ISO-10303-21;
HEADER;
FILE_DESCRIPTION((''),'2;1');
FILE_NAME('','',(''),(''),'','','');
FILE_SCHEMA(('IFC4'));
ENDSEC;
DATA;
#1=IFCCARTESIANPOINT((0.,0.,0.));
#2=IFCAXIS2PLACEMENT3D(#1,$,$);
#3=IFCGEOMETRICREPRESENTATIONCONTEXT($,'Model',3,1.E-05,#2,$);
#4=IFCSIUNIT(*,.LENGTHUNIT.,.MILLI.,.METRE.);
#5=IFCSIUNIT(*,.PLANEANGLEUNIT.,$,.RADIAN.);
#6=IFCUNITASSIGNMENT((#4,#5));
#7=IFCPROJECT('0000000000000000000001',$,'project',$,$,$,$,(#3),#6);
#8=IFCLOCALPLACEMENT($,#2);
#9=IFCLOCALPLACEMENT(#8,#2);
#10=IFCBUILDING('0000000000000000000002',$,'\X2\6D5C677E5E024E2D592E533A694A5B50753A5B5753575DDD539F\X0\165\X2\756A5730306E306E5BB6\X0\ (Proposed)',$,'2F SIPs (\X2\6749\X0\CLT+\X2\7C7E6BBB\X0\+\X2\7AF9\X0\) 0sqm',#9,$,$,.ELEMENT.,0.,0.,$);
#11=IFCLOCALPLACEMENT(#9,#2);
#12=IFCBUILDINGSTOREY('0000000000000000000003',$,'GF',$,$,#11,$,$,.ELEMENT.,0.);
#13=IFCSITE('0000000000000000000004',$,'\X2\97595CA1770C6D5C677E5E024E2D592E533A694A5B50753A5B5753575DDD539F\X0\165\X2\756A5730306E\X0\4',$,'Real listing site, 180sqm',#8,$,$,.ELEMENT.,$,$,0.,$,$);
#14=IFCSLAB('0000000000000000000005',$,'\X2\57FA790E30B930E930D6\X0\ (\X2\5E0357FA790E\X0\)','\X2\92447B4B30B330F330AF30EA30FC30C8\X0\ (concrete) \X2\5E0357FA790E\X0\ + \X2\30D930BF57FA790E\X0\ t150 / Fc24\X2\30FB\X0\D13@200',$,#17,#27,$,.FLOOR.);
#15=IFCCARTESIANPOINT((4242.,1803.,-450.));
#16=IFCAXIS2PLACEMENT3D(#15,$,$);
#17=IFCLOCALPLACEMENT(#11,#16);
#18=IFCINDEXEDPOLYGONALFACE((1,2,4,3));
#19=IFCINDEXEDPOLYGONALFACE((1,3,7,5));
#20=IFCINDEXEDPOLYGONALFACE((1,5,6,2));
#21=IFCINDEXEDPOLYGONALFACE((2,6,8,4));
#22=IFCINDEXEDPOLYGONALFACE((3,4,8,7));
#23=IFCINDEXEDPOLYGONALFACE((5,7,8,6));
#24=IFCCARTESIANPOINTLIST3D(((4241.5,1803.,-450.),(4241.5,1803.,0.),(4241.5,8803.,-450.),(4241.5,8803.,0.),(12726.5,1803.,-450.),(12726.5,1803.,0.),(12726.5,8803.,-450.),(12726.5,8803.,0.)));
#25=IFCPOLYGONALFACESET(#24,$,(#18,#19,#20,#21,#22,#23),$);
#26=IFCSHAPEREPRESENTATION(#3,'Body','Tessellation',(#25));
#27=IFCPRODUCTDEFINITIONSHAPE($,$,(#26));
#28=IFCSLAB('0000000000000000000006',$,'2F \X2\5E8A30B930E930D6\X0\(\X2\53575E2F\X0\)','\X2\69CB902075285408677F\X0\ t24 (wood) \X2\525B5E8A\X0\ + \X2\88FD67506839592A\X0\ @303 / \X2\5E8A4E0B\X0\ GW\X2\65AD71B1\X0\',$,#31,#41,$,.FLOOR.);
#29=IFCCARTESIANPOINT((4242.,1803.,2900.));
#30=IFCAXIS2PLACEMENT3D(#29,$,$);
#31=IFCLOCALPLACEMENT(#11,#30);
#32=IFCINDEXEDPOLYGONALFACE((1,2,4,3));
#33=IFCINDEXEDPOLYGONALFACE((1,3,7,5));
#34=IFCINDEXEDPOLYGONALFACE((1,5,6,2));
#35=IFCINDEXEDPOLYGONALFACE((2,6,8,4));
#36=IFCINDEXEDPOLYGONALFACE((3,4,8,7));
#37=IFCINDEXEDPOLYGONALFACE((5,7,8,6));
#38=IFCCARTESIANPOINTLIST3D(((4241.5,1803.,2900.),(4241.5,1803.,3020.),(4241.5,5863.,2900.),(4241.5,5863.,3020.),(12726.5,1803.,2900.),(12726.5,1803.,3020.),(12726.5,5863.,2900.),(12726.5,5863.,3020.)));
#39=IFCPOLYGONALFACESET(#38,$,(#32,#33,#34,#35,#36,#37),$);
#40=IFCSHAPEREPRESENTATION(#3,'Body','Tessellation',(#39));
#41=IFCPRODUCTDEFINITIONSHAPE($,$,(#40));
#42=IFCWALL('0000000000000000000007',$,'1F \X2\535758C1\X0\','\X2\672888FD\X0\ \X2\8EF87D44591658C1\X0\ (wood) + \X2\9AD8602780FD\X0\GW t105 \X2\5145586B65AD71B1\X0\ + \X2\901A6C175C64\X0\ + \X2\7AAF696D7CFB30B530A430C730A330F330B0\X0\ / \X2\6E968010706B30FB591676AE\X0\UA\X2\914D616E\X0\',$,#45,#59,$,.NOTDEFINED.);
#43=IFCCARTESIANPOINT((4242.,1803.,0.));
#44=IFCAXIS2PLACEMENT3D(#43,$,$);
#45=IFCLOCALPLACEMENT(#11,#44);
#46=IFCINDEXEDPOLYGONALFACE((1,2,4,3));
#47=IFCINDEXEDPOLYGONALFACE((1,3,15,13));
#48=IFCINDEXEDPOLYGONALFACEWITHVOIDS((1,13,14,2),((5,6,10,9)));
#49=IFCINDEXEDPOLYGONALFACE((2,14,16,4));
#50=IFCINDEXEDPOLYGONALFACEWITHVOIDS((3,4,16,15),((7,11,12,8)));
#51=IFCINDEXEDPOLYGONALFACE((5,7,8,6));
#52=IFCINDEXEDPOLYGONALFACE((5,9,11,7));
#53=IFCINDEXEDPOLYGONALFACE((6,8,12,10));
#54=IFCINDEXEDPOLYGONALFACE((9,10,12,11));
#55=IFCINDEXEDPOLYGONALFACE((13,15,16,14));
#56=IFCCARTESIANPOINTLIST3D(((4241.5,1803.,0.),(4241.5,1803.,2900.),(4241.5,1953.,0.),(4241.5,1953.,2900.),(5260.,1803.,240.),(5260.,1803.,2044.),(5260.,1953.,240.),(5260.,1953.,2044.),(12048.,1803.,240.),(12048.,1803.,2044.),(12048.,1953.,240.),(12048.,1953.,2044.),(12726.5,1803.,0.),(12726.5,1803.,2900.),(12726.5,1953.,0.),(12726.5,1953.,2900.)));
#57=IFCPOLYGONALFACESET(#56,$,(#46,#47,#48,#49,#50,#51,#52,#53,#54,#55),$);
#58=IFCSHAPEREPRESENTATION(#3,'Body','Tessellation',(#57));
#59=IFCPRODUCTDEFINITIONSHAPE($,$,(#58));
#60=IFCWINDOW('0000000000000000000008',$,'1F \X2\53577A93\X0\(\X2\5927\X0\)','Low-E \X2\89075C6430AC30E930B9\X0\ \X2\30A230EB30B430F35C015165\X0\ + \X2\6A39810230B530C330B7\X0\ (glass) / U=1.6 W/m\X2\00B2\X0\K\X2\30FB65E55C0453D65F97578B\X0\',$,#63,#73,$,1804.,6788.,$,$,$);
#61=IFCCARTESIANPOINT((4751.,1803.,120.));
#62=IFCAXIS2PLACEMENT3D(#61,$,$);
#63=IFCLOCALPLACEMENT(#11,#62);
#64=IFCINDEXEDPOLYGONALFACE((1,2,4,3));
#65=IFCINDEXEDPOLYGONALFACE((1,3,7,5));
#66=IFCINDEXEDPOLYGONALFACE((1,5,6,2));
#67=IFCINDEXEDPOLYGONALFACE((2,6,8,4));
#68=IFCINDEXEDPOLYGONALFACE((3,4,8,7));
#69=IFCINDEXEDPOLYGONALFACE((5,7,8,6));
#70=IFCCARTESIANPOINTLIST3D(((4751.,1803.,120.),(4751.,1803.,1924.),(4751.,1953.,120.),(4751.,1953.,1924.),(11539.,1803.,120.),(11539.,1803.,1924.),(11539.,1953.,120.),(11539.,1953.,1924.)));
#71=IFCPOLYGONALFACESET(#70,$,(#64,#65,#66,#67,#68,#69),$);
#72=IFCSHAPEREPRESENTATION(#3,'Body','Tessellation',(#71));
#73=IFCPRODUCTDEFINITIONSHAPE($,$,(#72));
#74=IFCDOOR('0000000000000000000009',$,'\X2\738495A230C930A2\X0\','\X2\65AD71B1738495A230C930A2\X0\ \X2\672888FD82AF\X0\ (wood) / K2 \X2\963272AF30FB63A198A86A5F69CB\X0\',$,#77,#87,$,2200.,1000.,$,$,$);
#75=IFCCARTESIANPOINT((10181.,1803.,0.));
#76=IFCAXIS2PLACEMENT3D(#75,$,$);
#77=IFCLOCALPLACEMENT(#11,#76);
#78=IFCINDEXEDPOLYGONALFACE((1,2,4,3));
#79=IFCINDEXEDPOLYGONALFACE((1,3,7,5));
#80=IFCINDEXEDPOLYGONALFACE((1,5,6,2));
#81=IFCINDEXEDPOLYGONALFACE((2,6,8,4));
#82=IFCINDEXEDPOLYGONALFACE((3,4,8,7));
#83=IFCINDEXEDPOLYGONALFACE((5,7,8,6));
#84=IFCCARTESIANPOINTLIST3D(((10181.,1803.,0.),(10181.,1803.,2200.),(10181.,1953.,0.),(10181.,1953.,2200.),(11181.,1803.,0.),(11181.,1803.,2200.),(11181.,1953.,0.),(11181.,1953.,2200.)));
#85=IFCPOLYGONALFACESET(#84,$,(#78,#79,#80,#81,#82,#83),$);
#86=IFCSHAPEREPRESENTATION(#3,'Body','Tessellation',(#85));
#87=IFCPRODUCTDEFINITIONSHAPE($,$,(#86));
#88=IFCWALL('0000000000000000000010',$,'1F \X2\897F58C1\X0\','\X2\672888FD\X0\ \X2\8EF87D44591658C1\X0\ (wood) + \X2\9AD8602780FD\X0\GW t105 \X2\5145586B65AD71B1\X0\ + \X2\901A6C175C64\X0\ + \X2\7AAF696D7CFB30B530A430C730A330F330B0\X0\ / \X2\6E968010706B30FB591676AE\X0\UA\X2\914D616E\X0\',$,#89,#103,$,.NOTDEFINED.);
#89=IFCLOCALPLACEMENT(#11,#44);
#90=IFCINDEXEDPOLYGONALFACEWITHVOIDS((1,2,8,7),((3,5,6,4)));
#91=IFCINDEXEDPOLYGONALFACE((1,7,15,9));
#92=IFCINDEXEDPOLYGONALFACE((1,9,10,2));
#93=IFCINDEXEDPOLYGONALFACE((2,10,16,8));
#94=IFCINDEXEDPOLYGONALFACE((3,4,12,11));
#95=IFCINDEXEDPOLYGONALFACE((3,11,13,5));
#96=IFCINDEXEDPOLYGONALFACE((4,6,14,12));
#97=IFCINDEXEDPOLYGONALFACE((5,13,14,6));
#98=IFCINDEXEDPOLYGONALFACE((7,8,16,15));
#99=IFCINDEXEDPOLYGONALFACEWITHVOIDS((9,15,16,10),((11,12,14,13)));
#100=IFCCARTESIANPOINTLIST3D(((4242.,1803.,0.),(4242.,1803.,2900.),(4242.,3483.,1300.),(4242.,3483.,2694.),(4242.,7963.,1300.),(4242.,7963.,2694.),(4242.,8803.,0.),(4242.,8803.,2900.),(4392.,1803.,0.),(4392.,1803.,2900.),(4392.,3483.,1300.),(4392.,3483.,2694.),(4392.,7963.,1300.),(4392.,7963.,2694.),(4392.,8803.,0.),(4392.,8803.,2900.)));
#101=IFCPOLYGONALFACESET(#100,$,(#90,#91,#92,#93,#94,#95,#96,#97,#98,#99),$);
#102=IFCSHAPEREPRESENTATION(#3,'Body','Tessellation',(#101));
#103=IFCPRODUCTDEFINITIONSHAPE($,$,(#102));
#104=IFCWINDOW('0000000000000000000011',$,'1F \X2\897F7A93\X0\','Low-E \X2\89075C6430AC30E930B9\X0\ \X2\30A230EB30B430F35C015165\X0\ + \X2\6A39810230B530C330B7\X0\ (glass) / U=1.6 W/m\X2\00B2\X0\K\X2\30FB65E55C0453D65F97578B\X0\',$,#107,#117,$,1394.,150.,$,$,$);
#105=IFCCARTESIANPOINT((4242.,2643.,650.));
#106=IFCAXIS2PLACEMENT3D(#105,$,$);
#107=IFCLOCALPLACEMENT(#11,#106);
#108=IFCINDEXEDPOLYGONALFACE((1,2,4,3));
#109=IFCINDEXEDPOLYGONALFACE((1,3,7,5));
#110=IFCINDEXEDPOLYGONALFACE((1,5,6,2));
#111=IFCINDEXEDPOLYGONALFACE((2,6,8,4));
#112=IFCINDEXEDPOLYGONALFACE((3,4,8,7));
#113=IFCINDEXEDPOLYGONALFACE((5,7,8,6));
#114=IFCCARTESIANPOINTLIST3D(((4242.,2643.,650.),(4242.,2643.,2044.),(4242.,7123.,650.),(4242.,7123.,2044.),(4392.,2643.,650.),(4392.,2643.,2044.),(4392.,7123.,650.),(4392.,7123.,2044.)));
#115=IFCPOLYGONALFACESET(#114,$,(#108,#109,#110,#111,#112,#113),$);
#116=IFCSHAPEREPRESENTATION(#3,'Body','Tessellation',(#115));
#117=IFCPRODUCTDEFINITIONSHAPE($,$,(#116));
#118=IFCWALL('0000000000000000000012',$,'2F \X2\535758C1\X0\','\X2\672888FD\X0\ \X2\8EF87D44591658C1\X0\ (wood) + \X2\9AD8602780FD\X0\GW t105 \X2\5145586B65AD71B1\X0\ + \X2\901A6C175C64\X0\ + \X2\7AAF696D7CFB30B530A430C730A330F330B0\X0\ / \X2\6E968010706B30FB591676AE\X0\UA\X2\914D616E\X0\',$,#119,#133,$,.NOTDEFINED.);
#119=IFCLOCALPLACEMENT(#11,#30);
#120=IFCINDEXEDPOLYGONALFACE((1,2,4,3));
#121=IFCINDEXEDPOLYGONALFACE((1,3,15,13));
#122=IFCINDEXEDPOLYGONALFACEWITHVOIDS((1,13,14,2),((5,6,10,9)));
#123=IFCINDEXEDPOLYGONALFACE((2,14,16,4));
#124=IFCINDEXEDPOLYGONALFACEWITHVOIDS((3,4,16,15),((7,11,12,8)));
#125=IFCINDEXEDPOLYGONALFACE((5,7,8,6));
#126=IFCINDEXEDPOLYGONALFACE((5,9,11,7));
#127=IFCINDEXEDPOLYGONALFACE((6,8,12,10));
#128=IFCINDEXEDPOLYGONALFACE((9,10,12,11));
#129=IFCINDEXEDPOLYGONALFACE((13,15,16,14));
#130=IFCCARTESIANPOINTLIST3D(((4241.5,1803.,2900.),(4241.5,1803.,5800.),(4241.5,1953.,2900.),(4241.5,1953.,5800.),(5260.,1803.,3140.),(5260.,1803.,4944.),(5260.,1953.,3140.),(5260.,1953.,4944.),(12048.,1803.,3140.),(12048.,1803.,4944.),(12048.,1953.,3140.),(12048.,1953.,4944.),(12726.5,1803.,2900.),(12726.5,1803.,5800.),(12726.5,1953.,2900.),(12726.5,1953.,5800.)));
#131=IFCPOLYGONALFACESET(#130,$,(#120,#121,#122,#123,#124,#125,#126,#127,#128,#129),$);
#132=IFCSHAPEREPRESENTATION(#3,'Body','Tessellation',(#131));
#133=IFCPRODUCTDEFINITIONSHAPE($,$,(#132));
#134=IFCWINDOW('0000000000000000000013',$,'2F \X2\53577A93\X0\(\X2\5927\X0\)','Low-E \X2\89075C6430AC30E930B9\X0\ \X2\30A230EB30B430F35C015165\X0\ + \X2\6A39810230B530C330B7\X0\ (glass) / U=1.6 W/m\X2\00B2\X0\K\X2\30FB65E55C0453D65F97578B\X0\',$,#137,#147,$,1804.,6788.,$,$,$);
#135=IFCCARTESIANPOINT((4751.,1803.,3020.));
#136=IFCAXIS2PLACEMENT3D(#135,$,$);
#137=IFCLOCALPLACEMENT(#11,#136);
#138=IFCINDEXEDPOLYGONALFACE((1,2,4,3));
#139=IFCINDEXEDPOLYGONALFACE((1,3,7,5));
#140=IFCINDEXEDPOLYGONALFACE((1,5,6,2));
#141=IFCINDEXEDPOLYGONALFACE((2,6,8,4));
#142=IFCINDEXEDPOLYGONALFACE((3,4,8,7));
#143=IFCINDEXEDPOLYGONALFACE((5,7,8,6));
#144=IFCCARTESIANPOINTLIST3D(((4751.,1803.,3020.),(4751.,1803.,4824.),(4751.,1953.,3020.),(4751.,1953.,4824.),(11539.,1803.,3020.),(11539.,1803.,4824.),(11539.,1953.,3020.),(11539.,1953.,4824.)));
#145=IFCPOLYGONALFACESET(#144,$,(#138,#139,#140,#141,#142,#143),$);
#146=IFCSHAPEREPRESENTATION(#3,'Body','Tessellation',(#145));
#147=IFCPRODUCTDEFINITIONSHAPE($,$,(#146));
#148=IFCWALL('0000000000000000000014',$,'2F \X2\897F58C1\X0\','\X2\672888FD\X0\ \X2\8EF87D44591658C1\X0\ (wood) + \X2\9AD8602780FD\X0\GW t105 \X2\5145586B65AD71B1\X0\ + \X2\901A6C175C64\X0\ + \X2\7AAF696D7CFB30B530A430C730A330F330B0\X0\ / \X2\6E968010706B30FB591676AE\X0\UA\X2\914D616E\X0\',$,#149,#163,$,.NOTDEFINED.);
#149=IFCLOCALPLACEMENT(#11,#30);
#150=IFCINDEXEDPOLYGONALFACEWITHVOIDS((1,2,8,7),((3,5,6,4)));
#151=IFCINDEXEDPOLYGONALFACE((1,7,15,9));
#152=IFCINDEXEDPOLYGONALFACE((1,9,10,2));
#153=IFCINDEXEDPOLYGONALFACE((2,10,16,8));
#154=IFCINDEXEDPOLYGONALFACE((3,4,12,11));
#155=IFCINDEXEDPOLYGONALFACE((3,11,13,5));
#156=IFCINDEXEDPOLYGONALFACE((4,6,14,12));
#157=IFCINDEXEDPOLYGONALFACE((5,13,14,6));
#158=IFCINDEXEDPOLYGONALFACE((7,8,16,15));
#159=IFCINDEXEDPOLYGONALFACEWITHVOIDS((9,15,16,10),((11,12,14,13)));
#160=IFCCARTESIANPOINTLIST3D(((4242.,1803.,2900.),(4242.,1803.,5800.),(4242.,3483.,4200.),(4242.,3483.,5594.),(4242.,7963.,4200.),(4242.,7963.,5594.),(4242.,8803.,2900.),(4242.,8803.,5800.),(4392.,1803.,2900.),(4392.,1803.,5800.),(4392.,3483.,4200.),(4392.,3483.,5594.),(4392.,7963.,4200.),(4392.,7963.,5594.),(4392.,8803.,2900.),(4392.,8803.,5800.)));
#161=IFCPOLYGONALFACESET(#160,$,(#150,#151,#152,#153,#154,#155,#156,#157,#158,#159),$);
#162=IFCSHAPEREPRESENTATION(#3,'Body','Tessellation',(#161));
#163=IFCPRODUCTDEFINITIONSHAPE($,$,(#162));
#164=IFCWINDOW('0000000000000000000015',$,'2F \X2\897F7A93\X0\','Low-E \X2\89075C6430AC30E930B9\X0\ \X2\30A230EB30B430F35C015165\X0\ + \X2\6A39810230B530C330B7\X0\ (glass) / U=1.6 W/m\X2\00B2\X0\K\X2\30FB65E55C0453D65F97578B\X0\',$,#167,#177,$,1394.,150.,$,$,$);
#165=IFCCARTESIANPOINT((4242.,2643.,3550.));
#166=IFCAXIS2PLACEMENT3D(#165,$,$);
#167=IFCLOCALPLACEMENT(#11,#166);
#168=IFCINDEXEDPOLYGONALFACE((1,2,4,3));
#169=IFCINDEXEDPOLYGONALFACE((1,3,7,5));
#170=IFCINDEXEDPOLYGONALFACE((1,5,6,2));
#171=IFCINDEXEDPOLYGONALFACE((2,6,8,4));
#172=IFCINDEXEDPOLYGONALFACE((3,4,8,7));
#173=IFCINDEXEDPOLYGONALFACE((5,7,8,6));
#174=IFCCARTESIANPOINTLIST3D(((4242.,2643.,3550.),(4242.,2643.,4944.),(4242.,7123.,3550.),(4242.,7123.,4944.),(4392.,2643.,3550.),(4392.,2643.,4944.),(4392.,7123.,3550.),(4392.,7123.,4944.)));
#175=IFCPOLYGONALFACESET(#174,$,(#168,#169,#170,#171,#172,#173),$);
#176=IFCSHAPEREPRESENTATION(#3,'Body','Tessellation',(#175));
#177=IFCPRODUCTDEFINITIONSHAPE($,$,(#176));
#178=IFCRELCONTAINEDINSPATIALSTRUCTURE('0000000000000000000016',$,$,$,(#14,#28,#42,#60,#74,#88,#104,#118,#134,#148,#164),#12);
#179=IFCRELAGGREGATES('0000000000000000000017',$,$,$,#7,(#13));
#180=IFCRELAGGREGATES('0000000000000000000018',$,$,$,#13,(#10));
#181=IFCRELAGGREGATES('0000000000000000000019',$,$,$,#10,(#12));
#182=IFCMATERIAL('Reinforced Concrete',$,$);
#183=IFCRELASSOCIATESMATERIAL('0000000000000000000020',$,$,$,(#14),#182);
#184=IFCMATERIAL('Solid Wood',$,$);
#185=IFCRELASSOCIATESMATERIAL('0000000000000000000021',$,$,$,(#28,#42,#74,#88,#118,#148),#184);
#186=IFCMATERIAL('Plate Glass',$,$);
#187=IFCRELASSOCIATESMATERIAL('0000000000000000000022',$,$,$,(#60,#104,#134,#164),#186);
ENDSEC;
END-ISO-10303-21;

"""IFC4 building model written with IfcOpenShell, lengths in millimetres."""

from ifc_helpers import new_model, si_unit, frame, frame_2d, origin, place, context, project, spatial, rectangle, extrude, material, element, fill, save


model = new_model("IFC4")

# Units and contexts
model_context = context("Model", 3, precision=1e-05, world=origin())
ifc_project = project(units=[si_unit("LENGTHUNIT", "METRE", prefix="MILLI"), si_unit("PLANEANGLEUNIT", "RADIAN")], contexts=[model_context])

# Site, building, storey
site_placement = place(None, origin())
site = spatial("IfcSite", under=ifc_project, at=site_placement, Name="静岡県浜松市中央区楊子町字南川原165番地の4", ObjectType="Real listing site, 180sqm", CompositionType="ELEMENT", RefElevation=0.0)
building_placement = place(site_placement, origin())
building = spatial("IfcBuilding", under=site, at=building_placement, Name="浜松市中央区楊子町字南川原165番地のの家 (Proposed)", ObjectType="2F SIPs (杉CLT+籾殻+竹) 0sqm", CompositionType="ELEMENT", ElevationOfRefHeight=0.0, ElevationOfTerrain=0.0)
storey_placement = place(building_placement, origin())
storey = spatial("IfcBuildingStorey", under=building, at=storey_placement, Name="GF", CompositionType="ELEMENT", Elevation=0.0)

# Slabs
ifc_material_1 = material(Name="Reinforced Concrete")
slab_1_placement = place(storey_placement, frame((4242.0, 1803.0, -450.0)))
element("IfcSlab", 1, at=slab_1_placement, inside=storey, material=ifc_material_1, Name="基礎スラブ (布基礎)", Description="鉄筋コンクリート (concrete) 布基礎 + ベタ基礎 t150 / Fc24・D13@200", PredefinedType="FLOOR", context=model_context, shape_type="SweptSolid", body=[
    extrude(rectangle(XDim=8485.0, YDim=7000.0, at=frame_2d((4242.0, 3500.0))), frame((4242.0, 1803.0, -450.0)), (0.0, 0.0, 1.0), 450.0),
])
ifc_material_2 = material(Name="Solid Wood")
slab_2_placement = place(storey_placement, frame((4242.0, 1803.0, 2900.0)))
element("IfcSlab", 2, at=slab_2_placement, inside=storey, material=ifc_material_2, Name="2F 床スラブ(南帯)", Description="構造用合板 t24 (wood) 剛床 + 製材根太 @303 / 床下 GW断熱", PredefinedType="FLOOR", context=model_context, shape_type="SweptSolid", body=[
    extrude(rectangle(XDim=8485.0, YDim=4060.0, at=frame_2d((4242.0, 2030.0))), frame((4242.0, 1803.0, 2900.0)), (0.0, 0.0, 1.0), 120.0),
])

# Wall, openings, window, door
wall_1_placement = place(storey_placement, frame((4242.0, 1803.0, 0.0)))
wall_1 = element("IfcWall", 3, at=wall_1_placement, inside=storey, material=ifc_material_2, Name="1F 南壁", Description="木製 軸組外壁 (wood) + 高性能GW t105 充填断熱 + 通気層 + 窯業系サイディング / 準耐火・外皮UA配慮", PredefinedType="NOTDEFINED", context=model_context, shape_type="SweptSolid", body=[
    extrude(rectangle(XDim=8485.0, YDim=150.0, at=frame_2d((4242.0, 75.0))), frame((4242.0, 1803.0, 0.0)), (0.0, 0.0, 1.0), 2900.0),
])
opening_1_placement = place(storey_placement, frame((4751.0, 1803.0, 120.0)))
opening_1 = element("IfcOpeningElement", 4, at=opening_1_placement, cuts=wall_1, PredefinedType="NOTDEFINED", context=model_context, shape_type="SweptSolid", body=[
    extrude(rectangle(XDim=6788.0, YDim=150.0, at=frame_2d((3394.0, 75.0))), frame((4751.0, 1803.0, 120.0)), (0.0, 0.0, 1.0), 1804.0),
])
opening_2_placement = place(storey_placement, frame((10181.0, 1803.0, 0.0)))
opening_2 = element("IfcOpeningElement", 5, at=opening_2_placement, cuts=wall_1, PredefinedType="NOTDEFINED", context=model_context, shape_type="SweptSolid", body=[
    extrude(rectangle(XDim=1000.0, YDim=150.0, at=frame_2d((500.0, 75.0))), frame((10181.0, 1803.0, 0.0)), (0.0, 0.0, 1.0), 2200.0),
])
ifc_material_3 = material(Name="Plate Glass")
window_1_placement = place(storey_placement, frame((4751.0, 1803.0, 120.0)))
window_1 = element("IfcWindow", 6, at=window_1_placement, inside=storey, material=ifc_material_3, Name="1F 南窓(大)", Description="Low-E 複層ガラス アルゴン封入 + 樹脂サッシ (glass) / U=1.6 W/m²K・日射取得型", OverallHeight=1804.0, OverallWidth=6788.0, context=model_context, shape_type="SweptSolid", body=[
    extrude(rectangle(XDim=6788.0, YDim=150.0, at=frame_2d((3394.0, 75.0))), frame((4751.0, 1803.0, 120.0)), (0.0, 0.0, 1.0), 1804.0),
])
fill(opening_1, window_1)
door_placement = place(storey_placement, frame((10181.0, 1803.0, 0.0)))
door = element("IfcDoor", 7, at=door_placement, inside=storey, material=ifc_material_2, Name="玄関ドア", Description="断熱玄関ドア 木製芯 (wood) / K2 防犯・採風機構", OverallHeight=2200.0, OverallWidth=1000.0, context=model_context, shape_type="SweptSolid", body=[
    extrude(rectangle(XDim=1000.0, YDim=150.0, at=frame_2d((500.0, 75.0))), frame((10181.0, 1803.0, 0.0)), (0.0, 0.0, 1.0), 2200.0),
])
fill(opening_2, door)

# Wall, opening, window
wall_2_placement = place(storey_placement, frame((4242.0, 1803.0, 0.0)))
wall_2 = element("IfcWall", 8, at=wall_2_placement, inside=storey, material=ifc_material_2, Name="1F 西壁", Description="木製 軸組外壁 (wood) + 高性能GW t105 充填断熱 + 通気層 + 窯業系サイディング / 準耐火・外皮UA配慮", PredefinedType="NOTDEFINED", context=model_context, shape_type="SweptSolid", body=[
    extrude(rectangle(XDim=150.0, YDim=7000.0, at=frame_2d((75.0, 3500.0))), frame((4242.0, 1803.0, 0.0)), (0.0, 0.0, 1.0), 2900.0),
])
opening_3_placement = place(storey_placement, frame((4242.0, 2643.0, 650.0)))
opening_3 = element("IfcOpeningElement", 9, at=opening_3_placement, cuts=wall_2, PredefinedType="NOTDEFINED", context=model_context, shape_type="SweptSolid", body=[
    extrude(rectangle(XDim=150.0, YDim=4480.0, at=frame_2d((75.0, 2240.0))), frame((4242.0, 2643.0, 650.0)), (0.0, 0.0, 1.0), 1394.0),
])
window_2_placement = place(storey_placement, frame((4242.0, 2643.0, 650.0)))
window_2 = element("IfcWindow", 10, at=window_2_placement, inside=storey, material=ifc_material_3, Name="1F 西窓", Description="Low-E 複層ガラス アルゴン封入 + 樹脂サッシ (glass) / U=1.6 W/m²K・日射取得型", OverallHeight=1394.0, OverallWidth=150.0, context=model_context, shape_type="SweptSolid", body=[
    extrude(rectangle(XDim=150.0, YDim=4480.0, at=frame_2d((75.0, 2240.0))), frame((4242.0, 2643.0, 650.0)), (0.0, 0.0, 1.0), 1394.0),
])
fill(opening_3, window_2)

# Walls, openings, windows
wall_3_placement = place(storey_placement, frame((4242.0, 1803.0, 2900.0)))
wall_3 = element("IfcWall", 11, at=wall_3_placement, inside=storey, material=ifc_material_2, Name="2F 南壁", Description="木製 軸組外壁 (wood) + 高性能GW t105 充填断熱 + 通気層 + 窯業系サイディング / 準耐火・外皮UA配慮", PredefinedType="NOTDEFINED", context=model_context, shape_type="SweptSolid", body=[
    extrude(rectangle(XDim=8485.0, YDim=150.0, at=frame_2d((4242.0, 75.0))), frame((4242.0, 1803.0, 2900.0)), (0.0, 0.0, 1.0), 2900.0),
])
opening_4_placement = place(storey_placement, frame((4751.0, 1803.0, 3020.0)))
opening_4 = element("IfcOpeningElement", 12, at=opening_4_placement, cuts=wall_3, PredefinedType="NOTDEFINED", context=model_context, shape_type="SweptSolid", body=[
    extrude(rectangle(XDim=6788.0, YDim=150.0, at=frame_2d((3394.0, 75.0))), frame((4751.0, 1803.0, 3020.0)), (0.0, 0.0, 1.0), 1804.0),
])
window_3_placement = place(storey_placement, frame((4751.0, 1803.0, 3020.0)))
window_3 = element("IfcWindow", 13, at=window_3_placement, inside=storey, material=ifc_material_3, Name="2F 南窓(大)", Description="Low-E 複層ガラス アルゴン封入 + 樹脂サッシ (glass) / U=1.6 W/m²K・日射取得型", OverallHeight=1804.0, OverallWidth=6788.0, context=model_context, shape_type="SweptSolid", body=[
    extrude(rectangle(XDim=6788.0, YDim=150.0, at=frame_2d((3394.0, 75.0))), frame((4751.0, 1803.0, 3020.0)), (0.0, 0.0, 1.0), 1804.0),
])
fill(opening_4, window_3)
wall_4_placement = place(storey_placement, frame((4242.0, 1803.0, 2900.0)))
wall_4 = element("IfcWall", 14, at=wall_4_placement, inside=storey, material=ifc_material_2, Name="2F 西壁", Description="木製 軸組外壁 (wood) + 高性能GW t105 充填断熱 + 通気層 + 窯業系サイディング / 準耐火・外皮UA配慮", PredefinedType="NOTDEFINED", context=model_context, shape_type="SweptSolid", body=[
    extrude(rectangle(XDim=150.0, YDim=7000.0, at=frame_2d((75.0, 3500.0))), frame((4242.0, 1803.0, 2900.0)), (0.0, 0.0, 1.0), 2900.0),
])
opening_5_placement = place(storey_placement, frame((4242.0, 2643.0, 3550.0)))
opening_5 = element("IfcOpeningElement", 15, at=opening_5_placement, cuts=wall_4, PredefinedType="NOTDEFINED", context=model_context, shape_type="SweptSolid", body=[
    extrude(rectangle(XDim=150.0, YDim=4480.0, at=frame_2d((75.0, 2240.0))), frame((4242.0, 2643.0, 3550.0)), (0.0, 0.0, 1.0), 1394.0),
])
window_4_placement = place(storey_placement, frame((4242.0, 2643.0, 3550.0)))
window_4 = element("IfcWindow", 16, at=window_4_placement, inside=storey, material=ifc_material_3, Name="2F 西窓", Description="Low-E 複層ガラス アルゴン封入 + 樹脂サッシ (glass) / U=1.6 W/m²K・日射取得型", OverallHeight=1394.0, OverallWidth=150.0, context=model_context, shape_type="SweptSolid", body=[
    extrude(rectangle(XDim=150.0, YDim=4480.0, at=frame_2d((75.0, 2240.0))), frame((4242.0, 2643.0, 3550.0)), (0.0, 0.0, 1.0), 1394.0),
])
fill(opening_5, window_4)

save(model, "model.ifc")
